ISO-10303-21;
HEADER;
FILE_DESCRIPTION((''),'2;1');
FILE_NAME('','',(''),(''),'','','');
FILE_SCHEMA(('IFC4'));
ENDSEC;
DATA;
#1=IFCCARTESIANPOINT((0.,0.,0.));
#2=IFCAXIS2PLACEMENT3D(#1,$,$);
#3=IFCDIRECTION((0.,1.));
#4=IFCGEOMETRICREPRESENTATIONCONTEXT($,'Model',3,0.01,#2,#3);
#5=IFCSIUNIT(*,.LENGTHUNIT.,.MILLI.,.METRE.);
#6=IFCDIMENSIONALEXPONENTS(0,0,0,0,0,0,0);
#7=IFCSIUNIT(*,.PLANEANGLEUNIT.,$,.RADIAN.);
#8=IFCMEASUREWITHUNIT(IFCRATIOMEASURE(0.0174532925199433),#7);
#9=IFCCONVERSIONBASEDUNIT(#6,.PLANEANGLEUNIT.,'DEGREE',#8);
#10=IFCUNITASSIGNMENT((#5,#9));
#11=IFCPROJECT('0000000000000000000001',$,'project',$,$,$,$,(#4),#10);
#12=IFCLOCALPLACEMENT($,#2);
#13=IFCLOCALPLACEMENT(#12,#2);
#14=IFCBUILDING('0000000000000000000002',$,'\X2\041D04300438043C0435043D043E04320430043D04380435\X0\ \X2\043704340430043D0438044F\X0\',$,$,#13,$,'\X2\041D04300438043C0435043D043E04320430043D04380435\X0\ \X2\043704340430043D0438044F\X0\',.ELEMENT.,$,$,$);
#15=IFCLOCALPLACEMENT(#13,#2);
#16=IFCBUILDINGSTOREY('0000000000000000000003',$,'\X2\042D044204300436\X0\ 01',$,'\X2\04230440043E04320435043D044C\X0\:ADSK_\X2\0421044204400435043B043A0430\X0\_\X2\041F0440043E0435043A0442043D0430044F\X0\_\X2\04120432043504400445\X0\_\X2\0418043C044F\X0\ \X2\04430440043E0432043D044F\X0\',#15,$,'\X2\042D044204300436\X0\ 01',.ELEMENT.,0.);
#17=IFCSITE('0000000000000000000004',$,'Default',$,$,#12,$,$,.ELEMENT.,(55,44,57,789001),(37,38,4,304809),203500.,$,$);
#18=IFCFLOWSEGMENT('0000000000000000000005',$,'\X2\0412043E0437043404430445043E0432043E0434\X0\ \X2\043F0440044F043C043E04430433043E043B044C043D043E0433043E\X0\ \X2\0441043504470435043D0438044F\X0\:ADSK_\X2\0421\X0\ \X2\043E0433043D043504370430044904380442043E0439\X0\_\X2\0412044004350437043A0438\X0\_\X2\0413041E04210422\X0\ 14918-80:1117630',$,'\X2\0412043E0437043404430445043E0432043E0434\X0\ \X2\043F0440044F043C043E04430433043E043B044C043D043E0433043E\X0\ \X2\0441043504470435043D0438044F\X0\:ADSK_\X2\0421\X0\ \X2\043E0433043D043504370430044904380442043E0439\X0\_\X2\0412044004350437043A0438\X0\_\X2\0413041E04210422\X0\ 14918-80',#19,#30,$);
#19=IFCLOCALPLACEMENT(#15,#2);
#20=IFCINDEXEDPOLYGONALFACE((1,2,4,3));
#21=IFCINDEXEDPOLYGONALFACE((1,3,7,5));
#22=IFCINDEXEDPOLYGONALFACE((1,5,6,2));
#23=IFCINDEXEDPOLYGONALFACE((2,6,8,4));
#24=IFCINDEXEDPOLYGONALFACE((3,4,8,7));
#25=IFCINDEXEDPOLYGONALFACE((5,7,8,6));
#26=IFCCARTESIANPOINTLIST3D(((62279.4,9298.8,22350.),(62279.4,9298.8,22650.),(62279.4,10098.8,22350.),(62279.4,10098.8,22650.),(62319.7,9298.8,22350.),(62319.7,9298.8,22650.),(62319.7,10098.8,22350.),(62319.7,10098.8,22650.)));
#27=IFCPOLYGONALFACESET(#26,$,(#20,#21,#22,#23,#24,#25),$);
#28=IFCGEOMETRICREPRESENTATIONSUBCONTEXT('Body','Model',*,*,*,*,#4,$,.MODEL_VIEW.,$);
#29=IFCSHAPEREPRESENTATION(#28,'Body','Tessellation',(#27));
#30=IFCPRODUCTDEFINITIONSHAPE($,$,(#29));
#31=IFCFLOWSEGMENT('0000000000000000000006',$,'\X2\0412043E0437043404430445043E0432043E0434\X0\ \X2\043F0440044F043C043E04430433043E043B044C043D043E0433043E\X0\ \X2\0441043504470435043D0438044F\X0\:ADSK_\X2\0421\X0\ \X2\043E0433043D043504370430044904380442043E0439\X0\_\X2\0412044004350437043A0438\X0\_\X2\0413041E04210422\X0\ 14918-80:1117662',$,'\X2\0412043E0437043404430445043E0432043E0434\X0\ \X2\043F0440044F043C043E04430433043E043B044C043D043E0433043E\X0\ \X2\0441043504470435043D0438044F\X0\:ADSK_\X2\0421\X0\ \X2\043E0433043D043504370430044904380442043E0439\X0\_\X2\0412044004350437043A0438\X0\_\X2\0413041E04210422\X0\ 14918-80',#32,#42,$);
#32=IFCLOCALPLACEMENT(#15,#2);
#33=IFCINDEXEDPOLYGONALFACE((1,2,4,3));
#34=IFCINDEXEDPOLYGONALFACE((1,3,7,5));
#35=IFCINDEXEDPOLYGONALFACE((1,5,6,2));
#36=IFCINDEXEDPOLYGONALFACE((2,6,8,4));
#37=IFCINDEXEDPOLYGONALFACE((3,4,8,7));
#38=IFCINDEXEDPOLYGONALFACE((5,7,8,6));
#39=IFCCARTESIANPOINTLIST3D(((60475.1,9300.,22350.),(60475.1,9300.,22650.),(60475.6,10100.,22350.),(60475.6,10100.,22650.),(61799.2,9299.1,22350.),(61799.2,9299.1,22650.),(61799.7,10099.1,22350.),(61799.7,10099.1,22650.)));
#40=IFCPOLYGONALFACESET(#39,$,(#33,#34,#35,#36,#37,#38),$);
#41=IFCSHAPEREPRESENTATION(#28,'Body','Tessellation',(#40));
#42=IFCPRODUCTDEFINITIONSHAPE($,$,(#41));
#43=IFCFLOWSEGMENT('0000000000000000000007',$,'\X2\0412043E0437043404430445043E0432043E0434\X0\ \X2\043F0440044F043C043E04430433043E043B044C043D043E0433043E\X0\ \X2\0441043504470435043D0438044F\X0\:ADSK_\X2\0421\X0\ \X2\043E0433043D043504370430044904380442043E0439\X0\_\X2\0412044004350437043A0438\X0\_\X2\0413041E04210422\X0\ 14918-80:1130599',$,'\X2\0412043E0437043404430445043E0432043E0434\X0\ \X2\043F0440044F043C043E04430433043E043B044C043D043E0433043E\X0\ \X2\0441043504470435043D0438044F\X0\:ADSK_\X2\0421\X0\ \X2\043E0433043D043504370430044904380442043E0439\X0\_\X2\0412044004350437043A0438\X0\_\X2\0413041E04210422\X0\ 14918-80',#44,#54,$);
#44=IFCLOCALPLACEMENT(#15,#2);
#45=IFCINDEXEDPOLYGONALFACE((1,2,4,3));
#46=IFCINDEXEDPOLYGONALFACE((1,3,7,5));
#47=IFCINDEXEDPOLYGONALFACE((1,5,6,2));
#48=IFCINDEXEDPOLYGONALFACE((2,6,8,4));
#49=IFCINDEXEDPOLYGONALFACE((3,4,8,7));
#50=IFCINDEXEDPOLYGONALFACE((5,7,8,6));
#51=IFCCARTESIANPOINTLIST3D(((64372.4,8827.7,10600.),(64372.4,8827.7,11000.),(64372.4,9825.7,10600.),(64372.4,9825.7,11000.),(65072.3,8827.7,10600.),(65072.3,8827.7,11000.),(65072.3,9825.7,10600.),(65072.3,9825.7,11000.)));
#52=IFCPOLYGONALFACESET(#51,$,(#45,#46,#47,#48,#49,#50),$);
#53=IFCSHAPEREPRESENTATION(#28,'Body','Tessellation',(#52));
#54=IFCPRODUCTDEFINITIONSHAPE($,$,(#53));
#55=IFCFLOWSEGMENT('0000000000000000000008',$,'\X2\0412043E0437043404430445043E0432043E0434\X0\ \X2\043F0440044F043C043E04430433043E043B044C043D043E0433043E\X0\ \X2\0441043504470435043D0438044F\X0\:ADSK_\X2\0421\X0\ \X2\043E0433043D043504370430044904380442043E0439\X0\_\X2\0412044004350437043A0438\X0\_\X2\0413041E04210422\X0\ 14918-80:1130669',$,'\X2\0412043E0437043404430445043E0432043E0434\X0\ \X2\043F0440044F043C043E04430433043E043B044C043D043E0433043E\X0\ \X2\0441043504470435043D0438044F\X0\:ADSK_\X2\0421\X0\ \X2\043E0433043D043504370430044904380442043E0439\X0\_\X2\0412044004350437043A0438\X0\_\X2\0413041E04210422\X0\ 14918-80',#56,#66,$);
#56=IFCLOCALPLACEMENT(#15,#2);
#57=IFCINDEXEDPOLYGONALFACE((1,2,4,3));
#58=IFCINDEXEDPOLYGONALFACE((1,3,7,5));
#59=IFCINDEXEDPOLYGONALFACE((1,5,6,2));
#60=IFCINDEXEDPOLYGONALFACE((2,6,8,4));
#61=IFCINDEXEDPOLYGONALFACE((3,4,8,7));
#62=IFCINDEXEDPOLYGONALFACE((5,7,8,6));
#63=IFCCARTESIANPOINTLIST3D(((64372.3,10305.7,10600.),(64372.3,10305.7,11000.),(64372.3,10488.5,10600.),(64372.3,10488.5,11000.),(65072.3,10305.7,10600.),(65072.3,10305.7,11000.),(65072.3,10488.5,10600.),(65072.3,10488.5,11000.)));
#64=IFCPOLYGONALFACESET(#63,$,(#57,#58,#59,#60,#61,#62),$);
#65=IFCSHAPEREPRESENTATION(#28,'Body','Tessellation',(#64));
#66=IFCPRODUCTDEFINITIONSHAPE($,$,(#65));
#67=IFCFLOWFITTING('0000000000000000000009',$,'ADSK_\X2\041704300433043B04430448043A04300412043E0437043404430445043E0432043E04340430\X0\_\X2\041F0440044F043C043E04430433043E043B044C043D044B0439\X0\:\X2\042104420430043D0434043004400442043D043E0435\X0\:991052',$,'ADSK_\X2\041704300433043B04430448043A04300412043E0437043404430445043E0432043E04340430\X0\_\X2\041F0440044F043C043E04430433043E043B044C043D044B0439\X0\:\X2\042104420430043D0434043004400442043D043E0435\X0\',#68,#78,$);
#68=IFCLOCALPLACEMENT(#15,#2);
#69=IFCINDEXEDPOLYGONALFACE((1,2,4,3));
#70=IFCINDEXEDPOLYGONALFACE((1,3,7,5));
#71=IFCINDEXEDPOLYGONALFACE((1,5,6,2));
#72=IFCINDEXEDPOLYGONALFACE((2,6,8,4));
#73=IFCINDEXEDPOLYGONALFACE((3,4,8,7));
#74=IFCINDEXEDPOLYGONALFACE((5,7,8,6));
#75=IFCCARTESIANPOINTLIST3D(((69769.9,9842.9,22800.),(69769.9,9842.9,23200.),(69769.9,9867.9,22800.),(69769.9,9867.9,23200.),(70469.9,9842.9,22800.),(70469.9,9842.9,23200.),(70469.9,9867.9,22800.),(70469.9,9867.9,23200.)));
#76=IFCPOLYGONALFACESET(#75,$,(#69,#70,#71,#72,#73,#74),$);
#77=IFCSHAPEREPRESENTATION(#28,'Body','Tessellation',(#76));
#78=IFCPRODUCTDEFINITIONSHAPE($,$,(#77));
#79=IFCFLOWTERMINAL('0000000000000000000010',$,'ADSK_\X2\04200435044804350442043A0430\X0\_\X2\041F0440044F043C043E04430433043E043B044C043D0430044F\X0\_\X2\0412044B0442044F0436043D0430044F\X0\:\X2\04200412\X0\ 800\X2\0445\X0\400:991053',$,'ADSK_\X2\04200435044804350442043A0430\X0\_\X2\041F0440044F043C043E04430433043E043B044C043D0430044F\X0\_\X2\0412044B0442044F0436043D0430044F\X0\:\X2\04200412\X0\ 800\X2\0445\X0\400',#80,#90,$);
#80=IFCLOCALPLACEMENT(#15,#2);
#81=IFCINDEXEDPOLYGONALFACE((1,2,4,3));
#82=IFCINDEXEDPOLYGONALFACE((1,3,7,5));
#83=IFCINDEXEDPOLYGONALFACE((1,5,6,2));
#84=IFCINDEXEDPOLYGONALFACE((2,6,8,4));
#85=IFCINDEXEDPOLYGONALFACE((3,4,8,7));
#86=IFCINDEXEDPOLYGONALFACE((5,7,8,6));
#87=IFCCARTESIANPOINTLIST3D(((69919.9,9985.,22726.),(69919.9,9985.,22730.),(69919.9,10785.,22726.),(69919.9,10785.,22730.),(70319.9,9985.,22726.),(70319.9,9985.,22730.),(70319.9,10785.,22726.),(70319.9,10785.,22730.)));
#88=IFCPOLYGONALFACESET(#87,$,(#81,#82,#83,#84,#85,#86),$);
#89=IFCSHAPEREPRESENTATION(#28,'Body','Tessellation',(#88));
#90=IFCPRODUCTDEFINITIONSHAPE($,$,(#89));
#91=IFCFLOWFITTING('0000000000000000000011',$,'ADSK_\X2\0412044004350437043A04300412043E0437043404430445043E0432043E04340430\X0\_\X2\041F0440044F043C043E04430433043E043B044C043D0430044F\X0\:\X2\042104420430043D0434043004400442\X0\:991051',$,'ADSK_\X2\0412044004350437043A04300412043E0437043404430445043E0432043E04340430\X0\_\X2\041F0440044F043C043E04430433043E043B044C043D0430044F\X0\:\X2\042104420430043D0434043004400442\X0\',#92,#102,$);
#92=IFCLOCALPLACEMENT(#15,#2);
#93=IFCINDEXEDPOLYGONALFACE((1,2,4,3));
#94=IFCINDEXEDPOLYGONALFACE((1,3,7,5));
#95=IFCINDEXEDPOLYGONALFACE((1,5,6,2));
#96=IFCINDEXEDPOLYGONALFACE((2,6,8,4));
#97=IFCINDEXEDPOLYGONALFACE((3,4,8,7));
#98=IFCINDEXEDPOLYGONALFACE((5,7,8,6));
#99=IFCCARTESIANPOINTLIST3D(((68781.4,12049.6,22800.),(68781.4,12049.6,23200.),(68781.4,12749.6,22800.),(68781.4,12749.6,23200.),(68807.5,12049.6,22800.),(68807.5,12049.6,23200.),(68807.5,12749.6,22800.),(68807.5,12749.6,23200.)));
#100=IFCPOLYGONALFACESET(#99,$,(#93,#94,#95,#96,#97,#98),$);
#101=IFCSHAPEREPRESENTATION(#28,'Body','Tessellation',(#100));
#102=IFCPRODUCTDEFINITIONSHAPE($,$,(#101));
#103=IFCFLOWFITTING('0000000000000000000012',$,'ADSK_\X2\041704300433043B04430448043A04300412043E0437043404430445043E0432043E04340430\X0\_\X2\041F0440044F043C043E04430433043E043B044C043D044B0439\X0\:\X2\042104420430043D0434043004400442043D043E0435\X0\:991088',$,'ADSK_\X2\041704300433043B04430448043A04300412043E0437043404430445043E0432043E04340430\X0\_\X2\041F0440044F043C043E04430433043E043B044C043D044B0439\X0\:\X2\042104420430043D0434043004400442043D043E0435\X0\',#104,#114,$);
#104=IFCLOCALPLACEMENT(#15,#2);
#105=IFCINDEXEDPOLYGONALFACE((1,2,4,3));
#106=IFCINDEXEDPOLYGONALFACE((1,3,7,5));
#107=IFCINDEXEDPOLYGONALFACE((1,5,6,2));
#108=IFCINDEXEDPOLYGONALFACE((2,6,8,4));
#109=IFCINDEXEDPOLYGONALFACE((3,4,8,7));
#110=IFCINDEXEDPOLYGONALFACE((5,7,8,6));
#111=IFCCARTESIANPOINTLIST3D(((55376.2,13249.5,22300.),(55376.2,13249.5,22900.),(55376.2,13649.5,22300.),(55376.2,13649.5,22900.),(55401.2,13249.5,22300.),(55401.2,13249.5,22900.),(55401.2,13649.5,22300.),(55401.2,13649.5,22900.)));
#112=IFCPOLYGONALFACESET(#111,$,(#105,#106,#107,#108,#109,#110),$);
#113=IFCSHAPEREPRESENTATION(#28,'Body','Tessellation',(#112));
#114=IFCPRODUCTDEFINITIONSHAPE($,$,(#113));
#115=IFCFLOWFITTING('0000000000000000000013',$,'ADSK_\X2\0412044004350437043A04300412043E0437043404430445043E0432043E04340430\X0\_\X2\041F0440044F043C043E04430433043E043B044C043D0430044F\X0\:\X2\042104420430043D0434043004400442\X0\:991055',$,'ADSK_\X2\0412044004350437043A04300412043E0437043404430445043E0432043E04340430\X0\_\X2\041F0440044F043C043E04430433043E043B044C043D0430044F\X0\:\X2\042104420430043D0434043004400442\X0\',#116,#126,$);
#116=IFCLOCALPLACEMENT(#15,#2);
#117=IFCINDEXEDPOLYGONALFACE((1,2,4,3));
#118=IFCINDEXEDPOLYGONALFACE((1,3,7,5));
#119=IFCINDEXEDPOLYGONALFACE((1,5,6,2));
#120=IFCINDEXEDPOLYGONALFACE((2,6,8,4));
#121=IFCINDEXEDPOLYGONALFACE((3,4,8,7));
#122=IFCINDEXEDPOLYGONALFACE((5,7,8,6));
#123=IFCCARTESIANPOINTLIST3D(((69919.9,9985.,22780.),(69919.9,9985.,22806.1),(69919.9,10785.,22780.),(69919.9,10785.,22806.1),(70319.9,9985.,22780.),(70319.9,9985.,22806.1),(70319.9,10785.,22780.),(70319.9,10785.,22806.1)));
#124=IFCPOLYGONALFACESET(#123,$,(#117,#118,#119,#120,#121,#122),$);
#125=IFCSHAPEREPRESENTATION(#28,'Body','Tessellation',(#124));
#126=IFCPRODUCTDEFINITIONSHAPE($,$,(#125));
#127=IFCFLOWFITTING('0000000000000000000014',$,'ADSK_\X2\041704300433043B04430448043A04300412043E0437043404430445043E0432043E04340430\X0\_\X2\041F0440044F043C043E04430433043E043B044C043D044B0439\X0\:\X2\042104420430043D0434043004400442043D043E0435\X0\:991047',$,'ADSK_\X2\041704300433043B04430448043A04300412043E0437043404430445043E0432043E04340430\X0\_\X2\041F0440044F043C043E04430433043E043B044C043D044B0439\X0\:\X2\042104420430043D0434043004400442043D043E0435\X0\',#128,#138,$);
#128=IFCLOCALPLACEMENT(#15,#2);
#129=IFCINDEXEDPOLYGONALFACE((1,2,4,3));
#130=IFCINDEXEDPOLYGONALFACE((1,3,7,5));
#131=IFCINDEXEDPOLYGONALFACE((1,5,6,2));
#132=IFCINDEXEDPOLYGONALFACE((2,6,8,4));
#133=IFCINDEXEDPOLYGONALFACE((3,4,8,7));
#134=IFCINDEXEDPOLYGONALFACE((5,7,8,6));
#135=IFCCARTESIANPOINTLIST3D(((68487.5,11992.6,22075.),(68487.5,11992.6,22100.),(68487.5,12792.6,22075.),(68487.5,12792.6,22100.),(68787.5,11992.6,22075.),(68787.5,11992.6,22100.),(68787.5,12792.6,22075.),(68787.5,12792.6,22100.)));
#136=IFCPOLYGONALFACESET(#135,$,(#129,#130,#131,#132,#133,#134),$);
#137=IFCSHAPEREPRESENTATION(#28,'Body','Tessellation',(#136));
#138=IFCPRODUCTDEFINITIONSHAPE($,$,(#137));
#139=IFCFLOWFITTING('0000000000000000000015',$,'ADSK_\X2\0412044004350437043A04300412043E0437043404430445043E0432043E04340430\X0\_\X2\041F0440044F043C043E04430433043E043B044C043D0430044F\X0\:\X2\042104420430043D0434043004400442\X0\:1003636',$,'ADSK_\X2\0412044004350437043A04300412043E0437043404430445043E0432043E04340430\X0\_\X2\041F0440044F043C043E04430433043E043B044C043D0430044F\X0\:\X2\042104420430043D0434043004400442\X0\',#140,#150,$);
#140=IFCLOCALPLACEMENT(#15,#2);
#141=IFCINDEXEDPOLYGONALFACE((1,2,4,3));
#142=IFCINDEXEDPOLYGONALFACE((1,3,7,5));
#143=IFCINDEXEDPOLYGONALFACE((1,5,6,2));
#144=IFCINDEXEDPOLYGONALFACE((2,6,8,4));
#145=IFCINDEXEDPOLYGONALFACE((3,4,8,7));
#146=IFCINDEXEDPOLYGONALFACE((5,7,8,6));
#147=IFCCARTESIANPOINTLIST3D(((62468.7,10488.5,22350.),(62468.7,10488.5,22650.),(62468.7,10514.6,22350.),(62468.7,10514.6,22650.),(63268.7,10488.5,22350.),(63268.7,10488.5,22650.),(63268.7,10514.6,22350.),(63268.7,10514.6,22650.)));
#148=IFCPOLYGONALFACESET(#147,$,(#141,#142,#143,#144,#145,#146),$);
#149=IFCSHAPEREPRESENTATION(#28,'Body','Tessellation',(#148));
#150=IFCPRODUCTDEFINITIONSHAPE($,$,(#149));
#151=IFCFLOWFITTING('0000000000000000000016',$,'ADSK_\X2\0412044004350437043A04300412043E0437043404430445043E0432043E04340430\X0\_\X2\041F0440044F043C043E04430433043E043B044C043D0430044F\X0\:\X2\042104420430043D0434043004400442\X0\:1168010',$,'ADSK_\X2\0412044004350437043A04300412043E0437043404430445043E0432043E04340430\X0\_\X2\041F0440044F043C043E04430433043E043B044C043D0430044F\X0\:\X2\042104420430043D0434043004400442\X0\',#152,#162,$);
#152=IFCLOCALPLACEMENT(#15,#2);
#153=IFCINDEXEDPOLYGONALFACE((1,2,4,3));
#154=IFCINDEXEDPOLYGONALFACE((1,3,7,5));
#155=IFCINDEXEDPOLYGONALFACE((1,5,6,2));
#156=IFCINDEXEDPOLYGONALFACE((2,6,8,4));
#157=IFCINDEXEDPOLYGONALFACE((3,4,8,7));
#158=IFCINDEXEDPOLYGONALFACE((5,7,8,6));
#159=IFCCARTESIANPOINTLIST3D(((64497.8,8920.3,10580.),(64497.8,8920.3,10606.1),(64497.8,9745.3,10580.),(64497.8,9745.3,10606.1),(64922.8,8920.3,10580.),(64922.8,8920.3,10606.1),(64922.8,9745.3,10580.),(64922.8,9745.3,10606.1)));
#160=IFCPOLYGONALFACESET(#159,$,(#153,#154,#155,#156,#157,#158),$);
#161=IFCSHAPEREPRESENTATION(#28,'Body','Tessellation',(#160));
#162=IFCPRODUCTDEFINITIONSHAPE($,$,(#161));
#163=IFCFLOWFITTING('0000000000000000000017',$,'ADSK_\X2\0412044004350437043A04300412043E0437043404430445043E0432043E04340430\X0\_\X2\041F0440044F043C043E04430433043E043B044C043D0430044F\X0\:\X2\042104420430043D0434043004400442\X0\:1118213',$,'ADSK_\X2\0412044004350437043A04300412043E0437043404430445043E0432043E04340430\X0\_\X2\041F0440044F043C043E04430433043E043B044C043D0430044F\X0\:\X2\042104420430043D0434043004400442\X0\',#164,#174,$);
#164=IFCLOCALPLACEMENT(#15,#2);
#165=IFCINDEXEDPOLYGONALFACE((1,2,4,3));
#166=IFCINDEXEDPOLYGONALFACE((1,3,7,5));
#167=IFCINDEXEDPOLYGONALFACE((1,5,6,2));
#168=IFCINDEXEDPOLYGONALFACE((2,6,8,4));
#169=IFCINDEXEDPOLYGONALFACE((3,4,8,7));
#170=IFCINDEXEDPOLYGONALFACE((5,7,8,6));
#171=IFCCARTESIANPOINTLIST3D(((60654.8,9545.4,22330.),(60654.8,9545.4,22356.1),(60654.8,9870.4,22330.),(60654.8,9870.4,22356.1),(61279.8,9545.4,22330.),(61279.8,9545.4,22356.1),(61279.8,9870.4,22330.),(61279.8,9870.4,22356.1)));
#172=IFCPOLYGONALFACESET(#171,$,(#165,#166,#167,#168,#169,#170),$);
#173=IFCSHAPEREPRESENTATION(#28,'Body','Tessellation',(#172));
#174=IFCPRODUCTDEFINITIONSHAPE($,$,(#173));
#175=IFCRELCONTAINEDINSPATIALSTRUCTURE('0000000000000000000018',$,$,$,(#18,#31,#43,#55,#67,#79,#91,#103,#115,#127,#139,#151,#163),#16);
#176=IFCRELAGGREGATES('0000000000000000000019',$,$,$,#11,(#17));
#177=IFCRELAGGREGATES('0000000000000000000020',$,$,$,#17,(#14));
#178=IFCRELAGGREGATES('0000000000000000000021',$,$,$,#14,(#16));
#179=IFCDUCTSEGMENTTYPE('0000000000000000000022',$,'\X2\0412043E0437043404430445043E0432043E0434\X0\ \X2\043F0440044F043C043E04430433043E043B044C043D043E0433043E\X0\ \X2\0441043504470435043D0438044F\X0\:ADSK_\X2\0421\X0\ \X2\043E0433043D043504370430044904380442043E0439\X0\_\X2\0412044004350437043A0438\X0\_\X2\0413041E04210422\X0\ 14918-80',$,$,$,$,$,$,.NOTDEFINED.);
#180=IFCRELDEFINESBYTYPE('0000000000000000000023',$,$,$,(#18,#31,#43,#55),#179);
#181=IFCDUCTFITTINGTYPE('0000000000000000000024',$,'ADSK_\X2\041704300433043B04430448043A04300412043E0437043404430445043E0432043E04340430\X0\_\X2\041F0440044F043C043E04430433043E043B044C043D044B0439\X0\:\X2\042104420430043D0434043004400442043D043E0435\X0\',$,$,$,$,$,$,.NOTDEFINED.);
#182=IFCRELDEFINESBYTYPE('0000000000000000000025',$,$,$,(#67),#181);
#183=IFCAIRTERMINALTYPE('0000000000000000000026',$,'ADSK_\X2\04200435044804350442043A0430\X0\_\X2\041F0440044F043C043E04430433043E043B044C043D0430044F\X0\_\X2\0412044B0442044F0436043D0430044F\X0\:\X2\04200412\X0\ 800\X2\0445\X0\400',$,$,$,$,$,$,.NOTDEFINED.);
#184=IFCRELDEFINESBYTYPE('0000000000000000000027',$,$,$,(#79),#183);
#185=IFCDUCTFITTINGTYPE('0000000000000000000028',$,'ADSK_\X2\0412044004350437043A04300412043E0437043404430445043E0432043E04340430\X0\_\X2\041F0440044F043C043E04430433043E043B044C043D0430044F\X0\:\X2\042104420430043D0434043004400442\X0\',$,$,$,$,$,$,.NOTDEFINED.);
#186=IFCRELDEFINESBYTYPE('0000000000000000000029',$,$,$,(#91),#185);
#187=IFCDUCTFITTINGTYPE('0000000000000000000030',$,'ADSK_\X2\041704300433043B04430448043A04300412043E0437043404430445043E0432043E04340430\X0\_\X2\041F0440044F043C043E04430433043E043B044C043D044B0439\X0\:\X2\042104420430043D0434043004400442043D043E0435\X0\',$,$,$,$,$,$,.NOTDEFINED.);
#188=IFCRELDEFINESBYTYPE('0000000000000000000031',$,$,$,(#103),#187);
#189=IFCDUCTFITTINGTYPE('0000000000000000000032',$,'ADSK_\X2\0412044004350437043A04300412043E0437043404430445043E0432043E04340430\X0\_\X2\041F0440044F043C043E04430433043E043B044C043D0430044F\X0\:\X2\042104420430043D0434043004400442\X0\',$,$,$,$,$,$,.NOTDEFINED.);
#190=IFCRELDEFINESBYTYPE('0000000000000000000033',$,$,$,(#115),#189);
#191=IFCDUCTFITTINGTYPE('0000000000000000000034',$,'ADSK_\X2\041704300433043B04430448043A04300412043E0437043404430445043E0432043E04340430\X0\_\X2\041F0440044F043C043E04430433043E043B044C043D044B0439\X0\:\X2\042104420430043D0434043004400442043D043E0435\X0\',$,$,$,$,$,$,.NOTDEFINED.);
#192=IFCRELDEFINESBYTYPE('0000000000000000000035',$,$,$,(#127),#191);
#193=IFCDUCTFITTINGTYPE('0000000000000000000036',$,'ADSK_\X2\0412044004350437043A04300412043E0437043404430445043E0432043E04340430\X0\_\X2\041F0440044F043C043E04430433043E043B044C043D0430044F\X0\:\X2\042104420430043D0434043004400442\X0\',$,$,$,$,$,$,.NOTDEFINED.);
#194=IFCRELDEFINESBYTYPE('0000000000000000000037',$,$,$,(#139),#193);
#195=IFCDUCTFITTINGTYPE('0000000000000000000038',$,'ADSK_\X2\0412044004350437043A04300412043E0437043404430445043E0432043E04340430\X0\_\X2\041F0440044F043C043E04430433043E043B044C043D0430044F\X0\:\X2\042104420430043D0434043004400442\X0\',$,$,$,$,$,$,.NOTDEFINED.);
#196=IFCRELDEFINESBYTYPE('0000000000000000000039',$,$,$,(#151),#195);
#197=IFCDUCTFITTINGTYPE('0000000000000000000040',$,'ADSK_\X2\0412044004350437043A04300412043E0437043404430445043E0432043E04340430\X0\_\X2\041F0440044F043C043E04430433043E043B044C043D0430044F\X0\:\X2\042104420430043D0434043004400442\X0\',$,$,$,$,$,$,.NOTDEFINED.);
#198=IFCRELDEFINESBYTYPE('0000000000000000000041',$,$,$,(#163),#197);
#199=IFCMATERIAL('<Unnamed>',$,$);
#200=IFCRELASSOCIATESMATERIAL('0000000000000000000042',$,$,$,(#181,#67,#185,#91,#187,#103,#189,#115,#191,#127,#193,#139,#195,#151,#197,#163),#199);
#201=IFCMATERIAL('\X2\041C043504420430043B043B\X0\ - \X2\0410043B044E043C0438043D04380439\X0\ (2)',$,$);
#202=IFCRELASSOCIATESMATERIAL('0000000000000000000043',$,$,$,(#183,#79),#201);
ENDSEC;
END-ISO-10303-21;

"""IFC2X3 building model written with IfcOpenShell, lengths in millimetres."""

from ifc_helpers import new_model, entity, si_unit, converted_unit, direction, frame, origin, origin_2d_with_axis, place, context, subcontext, project, spatial, rectangle, extrude, source, transform, mapped, material, type_object, type_shapes, element, save


model = new_model("IFC2X3")

# Units and contexts
model_context = context("Model", 3, precision=0.01, world=origin(), true_north=direction((0.0, 1.0)))
body_context = subcontext(model_context, "Body", "Model", "MODEL_VIEW")
ifc_project = project(units=[si_unit("LENGTHUNIT", "METRE", prefix="MILLI"), converted_unit("PLANEANGLEUNIT", "DEGREE", entity("IfcRatioMeasure", 0.0174532925199433), si_unit("PLANEANGLEUNIT", "RADIAN"), dimensions=[0, 0, 0, 0, 0, 0, 0])], contexts=[model_context])

# Site, building, storey
site_placement = place(None, origin())
site = spatial("IfcSite", under=ifc_project, at=site_placement, Name="Default", CompositionType="ELEMENT", RefLatitude=(55, 44, 57, 789001), RefLongitude=(37, 38, 4, 304809), RefElevation=203500.0)
building_placement = place(site_placement, origin())
building = spatial("IfcBuilding", under=site, at=building_placement, Name="Наименование здания", LongName="Наименование здания", CompositionType="ELEMENT")
storey_placement = place(building_placement, origin())
storey = spatial("IfcBuildingStorey", under=building, at=storey_placement, Name="Этаж 01", ObjectType="Уровень:ADSK_Стрелка_Проектная_Вверх_Имя уровня", LongName="Этаж 01", CompositionType="ELEMENT", Elevation=0.0)

# Flow segments
duct_segment_type = type_object("IfcDuctSegmentType", Name="Воздуховод прямоугольного сечения:ADSK_С огнезащитой_Врезки_ГОСТ 14918-80", PredefinedType="NOTDEFINED")
flow_segment_1_placement = place(storey_placement, frame((62279.4, 9298.8, 22350.0)))
element("IfcFlowSegment", 1, at=flow_segment_1_placement, inside=storey, type_object=duct_segment_type, Name="Воздуховод прямоугольного сечения:ADSK_С огнезащитой_Врезки_ГОСТ 14918-80:1117630", ObjectType="Воздуховод прямоугольного сечения:ADSK_С огнезащитой_Врезки_ГОСТ 14918-80", context=body_context, shape_type="SweptSolid", body=[
    extrude(rectangle(XDim=40.3, YDim=800.0, at=origin_2d_with_axis()), frame((20.1, 400.0, 0.0), z_axis=(0.0, 0.0, 1.0), x_axis=(-1.0, 0.0, 0.0)), (0.0, 0.0, 1.0), 300.0),
])
flow_segment_2_placement = place(storey_placement, frame((60475.1, 9299.1, 22350.0)))
element("IfcFlowSegment", 2, at=flow_segment_2_placement, inside=storey, type_object=duct_segment_type, Name="Воздуховод прямоугольного сечения:ADSK_С огнезащитой_Врезки_ГОСТ 14918-80:1117662", ObjectType="Воздуховод прямоугольного сечения:ADSK_С огнезащитой_Врезки_ГОСТ 14918-80", context=body_context, shape_type="SweptSolid", body=[
    extrude(rectangle(XDim=1324.1, YDim=800.0, at=origin_2d_with_axis()), frame((662.3, 400.4, 0.0), z_axis=(0.0, 0.0, 1.0), x_axis=(-1.0, 0.000623, 0.0)), (0.0, 0.0, 1.0), 300.0),
])
flow_segment_3_placement = place(storey_placement, frame((64372.3, 8827.7, 10600.0)))
element("IfcFlowSegment", 3, at=flow_segment_3_placement, inside=storey, type_object=duct_segment_type, Name="Воздуховод прямоугольного сечения:ADSK_С огнезащитой_Врезки_ГОСТ 14918-80:1130599", ObjectType="Воздуховод прямоугольного сечения:ADSK_С огнезащитой_Врезки_ГОСТ 14918-80", context=body_context, shape_type="SweptSolid", body=[
    extrude(rectangle(XDim=998.0, YDim=700.0, at=origin_2d_with_axis()), frame((350.0, 499.0, 0.0), z_axis=(0.0, 0.0, 1.0), x_axis=(0.0, -1.0, 0.0)), (0.0, 0.0, 1.0), 400.0),
])
flow_segment_4_placement = place(storey_placement, frame((64372.3, 10305.7, 10600.0)))
element("IfcFlowSegment", 4, at=flow_segment_4_placement, inside=storey, type_object=duct_segment_type, Name="Воздуховод прямоугольного сечения:ADSK_С огнезащитой_Врезки_ГОСТ 14918-80:1130669", ObjectType="Воздуховод прямоугольного сечения:ADSK_С огнезащитой_Врезки_ГОСТ 14918-80", context=body_context, shape_type="SweptSolid", body=[
    extrude(rectangle(XDim=182.8, YDim=700.0, at=origin_2d_with_axis()), frame((350.0, 91.4, 0.0), z_axis=(0.0, 0.0, 1.0), x_axis=(0.0, 1.0, 0.0)), (0.0, 0.0, 1.0), 400.0),
])

# Flow fitting
ifc_material_1 = material(Name="<Unnamed>")
duct_fitting_type_1 = type_object("IfcDuctFittingType", Name="ADSK_ЗаглушкаВоздуховода_Прямоугольный:Стандартное", PredefinedType="NOTDEFINED", material=ifc_material_1)
shared_shape_1 = source(origin(), body_context, "Body", "SweptSolid", [
    extrude(rectangle(XDim=25.0, YDim=700.0, at=origin_2d_with_axis()), frame((12.5, 0.0, -200.0)), (0.0, 0.0, 1.0), 400.0),
])
type_shapes(duct_fitting_type_1, [shared_shape_1])
flow_fitting_1_placement = place(storey_placement, frame((70119.9, 9867.9, 23000.0), z_axis=(0.0, 0.0, 1.0), x_axis=(0.0, -1.0, 0.0)))
element("IfcFlowFitting", 5, at=flow_fitting_1_placement, inside=storey, type_object=duct_fitting_type_1, material=ifc_material_1, Name="ADSK_ЗаглушкаВоздуховода_Прямоугольный:Стандартное:991052", ObjectType="ADSK_ЗаглушкаВоздуховода_Прямоугольный:Стандартное", context=body_context, shape_type="MappedRepresentation", body=[
    mapped(shared_shape_1, transform((0.0, 0.0, 0.0), scale=1.0)),
])

# Flow terminal
ifc_material_2 = material(Name="Металл - Алюминий (2)")
air_terminal_type = type_object("IfcAirTerminalType", Name="ADSK_Решетка_Прямоугольная_Вытяжная:РВ 800х400", PredefinedType="NOTDEFINED", material=ifc_material_2)
shared_shape_2 = source(origin(), body_context, "Body", "SweptSolid", [
    extrude(rectangle(XDim=4.0, YDim=800.0, at=origin_2d_with_axis()), frame((0.0, -2.0, -200.0), z_axis=(0.0, 0.0, 1.0), x_axis=(0.0, 1.0, 0.0)), (0.0, 0.0, 1.0), 400.0),
])
type_shapes(air_terminal_type, [shared_shape_2])
flow_terminal_placement = place(storey_placement, frame((70119.9, 10385.0, 22730.0), z_axis=(1.0, 0.0, 0.0), x_axis=(0.0, 1.0, 0.0)))
element("IfcFlowTerminal", 6, at=flow_terminal_placement, inside=storey, type_object=air_terminal_type, material=ifc_material_2, Name="ADSK_Решетка_Прямоугольная_Вытяжная:РВ 800х400:991053", ObjectType="ADSK_Решетка_Прямоугольная_Вытяжная:РВ 800х400", context=body_context, shape_type="MappedRepresentation", body=[
    mapped(shared_shape_2, transform((0.0, 0.0, 0.0), scale=1.0)),
])

# Flow fittings
duct_fitting_type_2 = type_object("IfcDuctFittingType", Name="ADSK_ВрезкаВоздуховода_Прямоугольная:Стандарт", PredefinedType="NOTDEFINED", material=ifc_material_1)
shared_shape_3 = source(origin(), body_context, "Body", "SweptSolid", [
    extrude(rectangle(XDim=26.1, YDim=400.0, at=origin_2d_with_axis()), frame((7.0, 0.0, -350.0)), (0.0, 0.0, 1.0), 700.0),
])
type_shapes(duct_fitting_type_2, [shared_shape_3])
flow_fitting_2_placement = place(storey_placement, frame((68787.5, 12399.6, 23000.0), z_axis=(0.0, -1.0, 0.0), x_axis=(1.0, 0.0, 0.0)))
element("IfcFlowFitting", 7, at=flow_fitting_2_placement, inside=storey, type_object=duct_fitting_type_2, material=ifc_material_1, Name="ADSK_ВрезкаВоздуховода_Прямоугольная:Стандарт:991051", ObjectType="ADSK_ВрезкаВоздуховода_Прямоугольная:Стандарт", context=body_context, shape_type="MappedRepresentation", body=[
    mapped(shared_shape_3, transform((0.0, 0.0, 0.0), scale=1.0)),
])
duct_fitting_type_3 = type_object("IfcDuctFittingType", Name="ADSK_ЗаглушкаВоздуховода_Прямоугольный:Стандартное", PredefinedType="NOTDEFINED", material=ifc_material_1)
shared_shape_4 = source(origin(), body_context, "Body", "SweptSolid", [
    extrude(rectangle(XDim=25.0, YDim=400.0, at=origin_2d_with_axis()), frame((12.5, 0.0, -300.0)), (0.0, 0.0, 1.0), 600.0),
])
type_shapes(duct_fitting_type_3, [shared_shape_4])
flow_fitting_3_placement = place(storey_placement, frame((55376.2, 13449.5, 22600.0)))
element("IfcFlowFitting", 8, at=flow_fitting_3_placement, inside=storey, type_object=duct_fitting_type_3, material=ifc_material_1, Name="ADSK_ЗаглушкаВоздуховода_Прямоугольный:Стандартное:991088", ObjectType="ADSK_ЗаглушкаВоздуховода_Прямоугольный:Стандартное", context=body_context, shape_type="MappedRepresentation", body=[
    mapped(shared_shape_4, transform((0.0, 0.0, 0.0), scale=1.0)),
])
duct_fitting_type_4 = type_object("IfcDuctFittingType", Name="ADSK_ВрезкаВоздуховода_Прямоугольная:Стандарт", PredefinedType="NOTDEFINED", material=ifc_material_1)
shared_shape_5 = source(origin(), body_context, "Body", "SweptSolid", [
    extrude(rectangle(XDim=400.0, YDim=26.1, at=origin_2d_with_axis()), frame((7.0, 0.0, -400.0), z_axis=(0.0, 0.0, 1.0), x_axis=(0.0, -1.0, 0.0)), (0.0, 0.0, 1.0), 800.0),
])
type_shapes(duct_fitting_type_4, [shared_shape_5])
flow_fitting_4_placement = place(storey_placement, frame((70119.9, 10385.0, 22800.0), z_axis=(0.0, -1.0, 0.0), x_axis=(0.0, 0.0, -1.0)))
element("IfcFlowFitting", 9, at=flow_fitting_4_placement, inside=storey, type_object=duct_fitting_type_4, material=ifc_material_1, Name="ADSK_ВрезкаВоздуховода_Прямоугольная:Стандарт:991055", ObjectType="ADSK_ВрезкаВоздуховода_Прямоугольная:Стандарт", context=body_context, shape_type="MappedRepresentation", body=[
    mapped(shared_shape_5, transform((0.0, 0.0, 0.0), scale=1.0)),
])
duct_fitting_type_5 = type_object("IfcDuctFittingType", Name="ADSK_ЗаглушкаВоздуховода_Прямоугольный:Стандартное", PredefinedType="NOTDEFINED", material=ifc_material_1)
shared_shape_6 = source(origin(), body_context, "Body", "SweptSolid", [
    extrude(rectangle(XDim=25.0, YDim=300.0, at=origin_2d_with_axis()), frame((12.5, 0.0, -400.0)), (0.0, 0.0, 1.0), 800.0),
])
type_shapes(duct_fitting_type_5, [shared_shape_6])
flow_fitting_5_placement = place(storey_placement, frame((68637.5, 12392.6, 22100.0), z_axis=(0.0, -1.0, 0.0), x_axis=(0.0, 0.0, -1.0)))
element("IfcFlowFitting", 10, at=flow_fitting_5_placement, inside=storey, type_object=duct_fitting_type_5, material=ifc_material_1, Name="ADSK_ЗаглушкаВоздуховода_Прямоугольный:Стандартное:991047", ObjectType="ADSK_ЗаглушкаВоздуховода_Прямоугольный:Стандартное", context=body_context, shape_type="MappedRepresentation", body=[
    mapped(shared_shape_6, transform((0.0, 0.0, 0.0), scale=1.0)),
])
duct_fitting_type_6 = type_object("IfcDuctFittingType", Name="ADSK_ВрезкаВоздуховода_Прямоугольная:Стандарт", PredefinedType="NOTDEFINED", material=ifc_material_1)
shared_shape_7 = source(origin(), body_context, "Body", "SweptSolid", [
    extrude(rectangle(XDim=26.1, YDim=300.0, at=origin_2d_with_axis()), frame((7.0, 0.0, -400.0)), (0.0, 0.0, 1.0), 800.0),
])
type_shapes(duct_fitting_type_6, [shared_shape_7])
flow_fitting_6_placement = place(storey_placement, frame((62868.7, 10508.5, 22500.0), z_axis=(-1.0, 0.0, 0.0), x_axis=(0.0, -1.0, 0.0)))
element("IfcFlowFitting", 11, at=flow_fitting_6_placement, inside=storey, type_object=duct_fitting_type_6, material=ifc_material_1, Name="ADSK_ВрезкаВоздуховода_Прямоугольная:Стандарт:1003636", ObjectType="ADSK_ВрезкаВоздуховода_Прямоугольная:Стандарт", context=body_context, shape_type="MappedRepresentation", body=[
    mapped(shared_shape_7, transform((0.0, 0.0, 0.0), scale=1.0)),
])
duct_fitting_type_7 = type_object("IfcDuctFittingType", Name="ADSK_ВрезкаВоздуховода_Прямоугольная:Стандарт", PredefinedType="NOTDEFINED", material=ifc_material_1)
shared_shape_8 = source(origin(), body_context, "Body", "SweptSolid", [
    extrude(rectangle(XDim=425.0, YDim=26.1, at=origin_2d_with_axis()), frame((7.0, 0.0, -412.5), z_axis=(0.0, 0.0, 1.0), x_axis=(0.0, -1.0, 0.0)), (0.0, 0.0, 1.0), 825.0),
])
type_shapes(duct_fitting_type_7, [shared_shape_8])
flow_fitting_7_placement = place(storey_placement, frame((64710.3, 9332.8, 10600.0), z_axis=(0.0, 1.0, 0.0), x_axis=(0.0, 0.0, -1.0)))
element("IfcFlowFitting", 12, at=flow_fitting_7_placement, inside=storey, type_object=duct_fitting_type_7, material=ifc_material_1, Name="ADSK_ВрезкаВоздуховода_Прямоугольная:Стандарт:1168010", ObjectType="ADSK_ВрезкаВоздуховода_Прямоугольная:Стандарт", context=body_context, shape_type="MappedRepresentation", body=[
    mapped(shared_shape_8, transform((0.0, 0.0, 0.0), scale=1.0)),
])
duct_fitting_type_8 = type_object("IfcDuctFittingType", Name="ADSK_ВрезкаВоздуховода_Прямоугольная:Стандарт", PredefinedType="NOTDEFINED", material=ifc_material_1)
shared_shape_9 = source(origin(), body_context, "Body", "SweptSolid", [
    extrude(rectangle(XDim=26.1, YDim=625.0, at=origin_2d_with_axis()), frame((7.0, 0.0, -162.5)), (0.0, 0.0, 1.0), 325.0),
])
type_shapes(duct_fitting_type_8, [shared_shape_9])
flow_fitting_8_placement = place(storey_placement, frame((60967.3, 9708.0, 22350.0), z_axis=(0.0, -1.0, 0.0), x_axis=(0.0, 0.0, -1.0)))
element("IfcFlowFitting", 13, at=flow_fitting_8_placement, inside=storey, type_object=duct_fitting_type_8, material=ifc_material_1, Name="ADSK_ВрезкаВоздуховода_Прямоугольная:Стандарт:1118213", ObjectType="ADSK_ВрезкаВоздуховода_Прямоугольная:Стандарт", context=body_context, shape_type="MappedRepresentation", body=[
    mapped(shared_shape_9, transform((0.0, 0.0, 0.0), scale=1.0)),
])

save(model, "model.ifc")
